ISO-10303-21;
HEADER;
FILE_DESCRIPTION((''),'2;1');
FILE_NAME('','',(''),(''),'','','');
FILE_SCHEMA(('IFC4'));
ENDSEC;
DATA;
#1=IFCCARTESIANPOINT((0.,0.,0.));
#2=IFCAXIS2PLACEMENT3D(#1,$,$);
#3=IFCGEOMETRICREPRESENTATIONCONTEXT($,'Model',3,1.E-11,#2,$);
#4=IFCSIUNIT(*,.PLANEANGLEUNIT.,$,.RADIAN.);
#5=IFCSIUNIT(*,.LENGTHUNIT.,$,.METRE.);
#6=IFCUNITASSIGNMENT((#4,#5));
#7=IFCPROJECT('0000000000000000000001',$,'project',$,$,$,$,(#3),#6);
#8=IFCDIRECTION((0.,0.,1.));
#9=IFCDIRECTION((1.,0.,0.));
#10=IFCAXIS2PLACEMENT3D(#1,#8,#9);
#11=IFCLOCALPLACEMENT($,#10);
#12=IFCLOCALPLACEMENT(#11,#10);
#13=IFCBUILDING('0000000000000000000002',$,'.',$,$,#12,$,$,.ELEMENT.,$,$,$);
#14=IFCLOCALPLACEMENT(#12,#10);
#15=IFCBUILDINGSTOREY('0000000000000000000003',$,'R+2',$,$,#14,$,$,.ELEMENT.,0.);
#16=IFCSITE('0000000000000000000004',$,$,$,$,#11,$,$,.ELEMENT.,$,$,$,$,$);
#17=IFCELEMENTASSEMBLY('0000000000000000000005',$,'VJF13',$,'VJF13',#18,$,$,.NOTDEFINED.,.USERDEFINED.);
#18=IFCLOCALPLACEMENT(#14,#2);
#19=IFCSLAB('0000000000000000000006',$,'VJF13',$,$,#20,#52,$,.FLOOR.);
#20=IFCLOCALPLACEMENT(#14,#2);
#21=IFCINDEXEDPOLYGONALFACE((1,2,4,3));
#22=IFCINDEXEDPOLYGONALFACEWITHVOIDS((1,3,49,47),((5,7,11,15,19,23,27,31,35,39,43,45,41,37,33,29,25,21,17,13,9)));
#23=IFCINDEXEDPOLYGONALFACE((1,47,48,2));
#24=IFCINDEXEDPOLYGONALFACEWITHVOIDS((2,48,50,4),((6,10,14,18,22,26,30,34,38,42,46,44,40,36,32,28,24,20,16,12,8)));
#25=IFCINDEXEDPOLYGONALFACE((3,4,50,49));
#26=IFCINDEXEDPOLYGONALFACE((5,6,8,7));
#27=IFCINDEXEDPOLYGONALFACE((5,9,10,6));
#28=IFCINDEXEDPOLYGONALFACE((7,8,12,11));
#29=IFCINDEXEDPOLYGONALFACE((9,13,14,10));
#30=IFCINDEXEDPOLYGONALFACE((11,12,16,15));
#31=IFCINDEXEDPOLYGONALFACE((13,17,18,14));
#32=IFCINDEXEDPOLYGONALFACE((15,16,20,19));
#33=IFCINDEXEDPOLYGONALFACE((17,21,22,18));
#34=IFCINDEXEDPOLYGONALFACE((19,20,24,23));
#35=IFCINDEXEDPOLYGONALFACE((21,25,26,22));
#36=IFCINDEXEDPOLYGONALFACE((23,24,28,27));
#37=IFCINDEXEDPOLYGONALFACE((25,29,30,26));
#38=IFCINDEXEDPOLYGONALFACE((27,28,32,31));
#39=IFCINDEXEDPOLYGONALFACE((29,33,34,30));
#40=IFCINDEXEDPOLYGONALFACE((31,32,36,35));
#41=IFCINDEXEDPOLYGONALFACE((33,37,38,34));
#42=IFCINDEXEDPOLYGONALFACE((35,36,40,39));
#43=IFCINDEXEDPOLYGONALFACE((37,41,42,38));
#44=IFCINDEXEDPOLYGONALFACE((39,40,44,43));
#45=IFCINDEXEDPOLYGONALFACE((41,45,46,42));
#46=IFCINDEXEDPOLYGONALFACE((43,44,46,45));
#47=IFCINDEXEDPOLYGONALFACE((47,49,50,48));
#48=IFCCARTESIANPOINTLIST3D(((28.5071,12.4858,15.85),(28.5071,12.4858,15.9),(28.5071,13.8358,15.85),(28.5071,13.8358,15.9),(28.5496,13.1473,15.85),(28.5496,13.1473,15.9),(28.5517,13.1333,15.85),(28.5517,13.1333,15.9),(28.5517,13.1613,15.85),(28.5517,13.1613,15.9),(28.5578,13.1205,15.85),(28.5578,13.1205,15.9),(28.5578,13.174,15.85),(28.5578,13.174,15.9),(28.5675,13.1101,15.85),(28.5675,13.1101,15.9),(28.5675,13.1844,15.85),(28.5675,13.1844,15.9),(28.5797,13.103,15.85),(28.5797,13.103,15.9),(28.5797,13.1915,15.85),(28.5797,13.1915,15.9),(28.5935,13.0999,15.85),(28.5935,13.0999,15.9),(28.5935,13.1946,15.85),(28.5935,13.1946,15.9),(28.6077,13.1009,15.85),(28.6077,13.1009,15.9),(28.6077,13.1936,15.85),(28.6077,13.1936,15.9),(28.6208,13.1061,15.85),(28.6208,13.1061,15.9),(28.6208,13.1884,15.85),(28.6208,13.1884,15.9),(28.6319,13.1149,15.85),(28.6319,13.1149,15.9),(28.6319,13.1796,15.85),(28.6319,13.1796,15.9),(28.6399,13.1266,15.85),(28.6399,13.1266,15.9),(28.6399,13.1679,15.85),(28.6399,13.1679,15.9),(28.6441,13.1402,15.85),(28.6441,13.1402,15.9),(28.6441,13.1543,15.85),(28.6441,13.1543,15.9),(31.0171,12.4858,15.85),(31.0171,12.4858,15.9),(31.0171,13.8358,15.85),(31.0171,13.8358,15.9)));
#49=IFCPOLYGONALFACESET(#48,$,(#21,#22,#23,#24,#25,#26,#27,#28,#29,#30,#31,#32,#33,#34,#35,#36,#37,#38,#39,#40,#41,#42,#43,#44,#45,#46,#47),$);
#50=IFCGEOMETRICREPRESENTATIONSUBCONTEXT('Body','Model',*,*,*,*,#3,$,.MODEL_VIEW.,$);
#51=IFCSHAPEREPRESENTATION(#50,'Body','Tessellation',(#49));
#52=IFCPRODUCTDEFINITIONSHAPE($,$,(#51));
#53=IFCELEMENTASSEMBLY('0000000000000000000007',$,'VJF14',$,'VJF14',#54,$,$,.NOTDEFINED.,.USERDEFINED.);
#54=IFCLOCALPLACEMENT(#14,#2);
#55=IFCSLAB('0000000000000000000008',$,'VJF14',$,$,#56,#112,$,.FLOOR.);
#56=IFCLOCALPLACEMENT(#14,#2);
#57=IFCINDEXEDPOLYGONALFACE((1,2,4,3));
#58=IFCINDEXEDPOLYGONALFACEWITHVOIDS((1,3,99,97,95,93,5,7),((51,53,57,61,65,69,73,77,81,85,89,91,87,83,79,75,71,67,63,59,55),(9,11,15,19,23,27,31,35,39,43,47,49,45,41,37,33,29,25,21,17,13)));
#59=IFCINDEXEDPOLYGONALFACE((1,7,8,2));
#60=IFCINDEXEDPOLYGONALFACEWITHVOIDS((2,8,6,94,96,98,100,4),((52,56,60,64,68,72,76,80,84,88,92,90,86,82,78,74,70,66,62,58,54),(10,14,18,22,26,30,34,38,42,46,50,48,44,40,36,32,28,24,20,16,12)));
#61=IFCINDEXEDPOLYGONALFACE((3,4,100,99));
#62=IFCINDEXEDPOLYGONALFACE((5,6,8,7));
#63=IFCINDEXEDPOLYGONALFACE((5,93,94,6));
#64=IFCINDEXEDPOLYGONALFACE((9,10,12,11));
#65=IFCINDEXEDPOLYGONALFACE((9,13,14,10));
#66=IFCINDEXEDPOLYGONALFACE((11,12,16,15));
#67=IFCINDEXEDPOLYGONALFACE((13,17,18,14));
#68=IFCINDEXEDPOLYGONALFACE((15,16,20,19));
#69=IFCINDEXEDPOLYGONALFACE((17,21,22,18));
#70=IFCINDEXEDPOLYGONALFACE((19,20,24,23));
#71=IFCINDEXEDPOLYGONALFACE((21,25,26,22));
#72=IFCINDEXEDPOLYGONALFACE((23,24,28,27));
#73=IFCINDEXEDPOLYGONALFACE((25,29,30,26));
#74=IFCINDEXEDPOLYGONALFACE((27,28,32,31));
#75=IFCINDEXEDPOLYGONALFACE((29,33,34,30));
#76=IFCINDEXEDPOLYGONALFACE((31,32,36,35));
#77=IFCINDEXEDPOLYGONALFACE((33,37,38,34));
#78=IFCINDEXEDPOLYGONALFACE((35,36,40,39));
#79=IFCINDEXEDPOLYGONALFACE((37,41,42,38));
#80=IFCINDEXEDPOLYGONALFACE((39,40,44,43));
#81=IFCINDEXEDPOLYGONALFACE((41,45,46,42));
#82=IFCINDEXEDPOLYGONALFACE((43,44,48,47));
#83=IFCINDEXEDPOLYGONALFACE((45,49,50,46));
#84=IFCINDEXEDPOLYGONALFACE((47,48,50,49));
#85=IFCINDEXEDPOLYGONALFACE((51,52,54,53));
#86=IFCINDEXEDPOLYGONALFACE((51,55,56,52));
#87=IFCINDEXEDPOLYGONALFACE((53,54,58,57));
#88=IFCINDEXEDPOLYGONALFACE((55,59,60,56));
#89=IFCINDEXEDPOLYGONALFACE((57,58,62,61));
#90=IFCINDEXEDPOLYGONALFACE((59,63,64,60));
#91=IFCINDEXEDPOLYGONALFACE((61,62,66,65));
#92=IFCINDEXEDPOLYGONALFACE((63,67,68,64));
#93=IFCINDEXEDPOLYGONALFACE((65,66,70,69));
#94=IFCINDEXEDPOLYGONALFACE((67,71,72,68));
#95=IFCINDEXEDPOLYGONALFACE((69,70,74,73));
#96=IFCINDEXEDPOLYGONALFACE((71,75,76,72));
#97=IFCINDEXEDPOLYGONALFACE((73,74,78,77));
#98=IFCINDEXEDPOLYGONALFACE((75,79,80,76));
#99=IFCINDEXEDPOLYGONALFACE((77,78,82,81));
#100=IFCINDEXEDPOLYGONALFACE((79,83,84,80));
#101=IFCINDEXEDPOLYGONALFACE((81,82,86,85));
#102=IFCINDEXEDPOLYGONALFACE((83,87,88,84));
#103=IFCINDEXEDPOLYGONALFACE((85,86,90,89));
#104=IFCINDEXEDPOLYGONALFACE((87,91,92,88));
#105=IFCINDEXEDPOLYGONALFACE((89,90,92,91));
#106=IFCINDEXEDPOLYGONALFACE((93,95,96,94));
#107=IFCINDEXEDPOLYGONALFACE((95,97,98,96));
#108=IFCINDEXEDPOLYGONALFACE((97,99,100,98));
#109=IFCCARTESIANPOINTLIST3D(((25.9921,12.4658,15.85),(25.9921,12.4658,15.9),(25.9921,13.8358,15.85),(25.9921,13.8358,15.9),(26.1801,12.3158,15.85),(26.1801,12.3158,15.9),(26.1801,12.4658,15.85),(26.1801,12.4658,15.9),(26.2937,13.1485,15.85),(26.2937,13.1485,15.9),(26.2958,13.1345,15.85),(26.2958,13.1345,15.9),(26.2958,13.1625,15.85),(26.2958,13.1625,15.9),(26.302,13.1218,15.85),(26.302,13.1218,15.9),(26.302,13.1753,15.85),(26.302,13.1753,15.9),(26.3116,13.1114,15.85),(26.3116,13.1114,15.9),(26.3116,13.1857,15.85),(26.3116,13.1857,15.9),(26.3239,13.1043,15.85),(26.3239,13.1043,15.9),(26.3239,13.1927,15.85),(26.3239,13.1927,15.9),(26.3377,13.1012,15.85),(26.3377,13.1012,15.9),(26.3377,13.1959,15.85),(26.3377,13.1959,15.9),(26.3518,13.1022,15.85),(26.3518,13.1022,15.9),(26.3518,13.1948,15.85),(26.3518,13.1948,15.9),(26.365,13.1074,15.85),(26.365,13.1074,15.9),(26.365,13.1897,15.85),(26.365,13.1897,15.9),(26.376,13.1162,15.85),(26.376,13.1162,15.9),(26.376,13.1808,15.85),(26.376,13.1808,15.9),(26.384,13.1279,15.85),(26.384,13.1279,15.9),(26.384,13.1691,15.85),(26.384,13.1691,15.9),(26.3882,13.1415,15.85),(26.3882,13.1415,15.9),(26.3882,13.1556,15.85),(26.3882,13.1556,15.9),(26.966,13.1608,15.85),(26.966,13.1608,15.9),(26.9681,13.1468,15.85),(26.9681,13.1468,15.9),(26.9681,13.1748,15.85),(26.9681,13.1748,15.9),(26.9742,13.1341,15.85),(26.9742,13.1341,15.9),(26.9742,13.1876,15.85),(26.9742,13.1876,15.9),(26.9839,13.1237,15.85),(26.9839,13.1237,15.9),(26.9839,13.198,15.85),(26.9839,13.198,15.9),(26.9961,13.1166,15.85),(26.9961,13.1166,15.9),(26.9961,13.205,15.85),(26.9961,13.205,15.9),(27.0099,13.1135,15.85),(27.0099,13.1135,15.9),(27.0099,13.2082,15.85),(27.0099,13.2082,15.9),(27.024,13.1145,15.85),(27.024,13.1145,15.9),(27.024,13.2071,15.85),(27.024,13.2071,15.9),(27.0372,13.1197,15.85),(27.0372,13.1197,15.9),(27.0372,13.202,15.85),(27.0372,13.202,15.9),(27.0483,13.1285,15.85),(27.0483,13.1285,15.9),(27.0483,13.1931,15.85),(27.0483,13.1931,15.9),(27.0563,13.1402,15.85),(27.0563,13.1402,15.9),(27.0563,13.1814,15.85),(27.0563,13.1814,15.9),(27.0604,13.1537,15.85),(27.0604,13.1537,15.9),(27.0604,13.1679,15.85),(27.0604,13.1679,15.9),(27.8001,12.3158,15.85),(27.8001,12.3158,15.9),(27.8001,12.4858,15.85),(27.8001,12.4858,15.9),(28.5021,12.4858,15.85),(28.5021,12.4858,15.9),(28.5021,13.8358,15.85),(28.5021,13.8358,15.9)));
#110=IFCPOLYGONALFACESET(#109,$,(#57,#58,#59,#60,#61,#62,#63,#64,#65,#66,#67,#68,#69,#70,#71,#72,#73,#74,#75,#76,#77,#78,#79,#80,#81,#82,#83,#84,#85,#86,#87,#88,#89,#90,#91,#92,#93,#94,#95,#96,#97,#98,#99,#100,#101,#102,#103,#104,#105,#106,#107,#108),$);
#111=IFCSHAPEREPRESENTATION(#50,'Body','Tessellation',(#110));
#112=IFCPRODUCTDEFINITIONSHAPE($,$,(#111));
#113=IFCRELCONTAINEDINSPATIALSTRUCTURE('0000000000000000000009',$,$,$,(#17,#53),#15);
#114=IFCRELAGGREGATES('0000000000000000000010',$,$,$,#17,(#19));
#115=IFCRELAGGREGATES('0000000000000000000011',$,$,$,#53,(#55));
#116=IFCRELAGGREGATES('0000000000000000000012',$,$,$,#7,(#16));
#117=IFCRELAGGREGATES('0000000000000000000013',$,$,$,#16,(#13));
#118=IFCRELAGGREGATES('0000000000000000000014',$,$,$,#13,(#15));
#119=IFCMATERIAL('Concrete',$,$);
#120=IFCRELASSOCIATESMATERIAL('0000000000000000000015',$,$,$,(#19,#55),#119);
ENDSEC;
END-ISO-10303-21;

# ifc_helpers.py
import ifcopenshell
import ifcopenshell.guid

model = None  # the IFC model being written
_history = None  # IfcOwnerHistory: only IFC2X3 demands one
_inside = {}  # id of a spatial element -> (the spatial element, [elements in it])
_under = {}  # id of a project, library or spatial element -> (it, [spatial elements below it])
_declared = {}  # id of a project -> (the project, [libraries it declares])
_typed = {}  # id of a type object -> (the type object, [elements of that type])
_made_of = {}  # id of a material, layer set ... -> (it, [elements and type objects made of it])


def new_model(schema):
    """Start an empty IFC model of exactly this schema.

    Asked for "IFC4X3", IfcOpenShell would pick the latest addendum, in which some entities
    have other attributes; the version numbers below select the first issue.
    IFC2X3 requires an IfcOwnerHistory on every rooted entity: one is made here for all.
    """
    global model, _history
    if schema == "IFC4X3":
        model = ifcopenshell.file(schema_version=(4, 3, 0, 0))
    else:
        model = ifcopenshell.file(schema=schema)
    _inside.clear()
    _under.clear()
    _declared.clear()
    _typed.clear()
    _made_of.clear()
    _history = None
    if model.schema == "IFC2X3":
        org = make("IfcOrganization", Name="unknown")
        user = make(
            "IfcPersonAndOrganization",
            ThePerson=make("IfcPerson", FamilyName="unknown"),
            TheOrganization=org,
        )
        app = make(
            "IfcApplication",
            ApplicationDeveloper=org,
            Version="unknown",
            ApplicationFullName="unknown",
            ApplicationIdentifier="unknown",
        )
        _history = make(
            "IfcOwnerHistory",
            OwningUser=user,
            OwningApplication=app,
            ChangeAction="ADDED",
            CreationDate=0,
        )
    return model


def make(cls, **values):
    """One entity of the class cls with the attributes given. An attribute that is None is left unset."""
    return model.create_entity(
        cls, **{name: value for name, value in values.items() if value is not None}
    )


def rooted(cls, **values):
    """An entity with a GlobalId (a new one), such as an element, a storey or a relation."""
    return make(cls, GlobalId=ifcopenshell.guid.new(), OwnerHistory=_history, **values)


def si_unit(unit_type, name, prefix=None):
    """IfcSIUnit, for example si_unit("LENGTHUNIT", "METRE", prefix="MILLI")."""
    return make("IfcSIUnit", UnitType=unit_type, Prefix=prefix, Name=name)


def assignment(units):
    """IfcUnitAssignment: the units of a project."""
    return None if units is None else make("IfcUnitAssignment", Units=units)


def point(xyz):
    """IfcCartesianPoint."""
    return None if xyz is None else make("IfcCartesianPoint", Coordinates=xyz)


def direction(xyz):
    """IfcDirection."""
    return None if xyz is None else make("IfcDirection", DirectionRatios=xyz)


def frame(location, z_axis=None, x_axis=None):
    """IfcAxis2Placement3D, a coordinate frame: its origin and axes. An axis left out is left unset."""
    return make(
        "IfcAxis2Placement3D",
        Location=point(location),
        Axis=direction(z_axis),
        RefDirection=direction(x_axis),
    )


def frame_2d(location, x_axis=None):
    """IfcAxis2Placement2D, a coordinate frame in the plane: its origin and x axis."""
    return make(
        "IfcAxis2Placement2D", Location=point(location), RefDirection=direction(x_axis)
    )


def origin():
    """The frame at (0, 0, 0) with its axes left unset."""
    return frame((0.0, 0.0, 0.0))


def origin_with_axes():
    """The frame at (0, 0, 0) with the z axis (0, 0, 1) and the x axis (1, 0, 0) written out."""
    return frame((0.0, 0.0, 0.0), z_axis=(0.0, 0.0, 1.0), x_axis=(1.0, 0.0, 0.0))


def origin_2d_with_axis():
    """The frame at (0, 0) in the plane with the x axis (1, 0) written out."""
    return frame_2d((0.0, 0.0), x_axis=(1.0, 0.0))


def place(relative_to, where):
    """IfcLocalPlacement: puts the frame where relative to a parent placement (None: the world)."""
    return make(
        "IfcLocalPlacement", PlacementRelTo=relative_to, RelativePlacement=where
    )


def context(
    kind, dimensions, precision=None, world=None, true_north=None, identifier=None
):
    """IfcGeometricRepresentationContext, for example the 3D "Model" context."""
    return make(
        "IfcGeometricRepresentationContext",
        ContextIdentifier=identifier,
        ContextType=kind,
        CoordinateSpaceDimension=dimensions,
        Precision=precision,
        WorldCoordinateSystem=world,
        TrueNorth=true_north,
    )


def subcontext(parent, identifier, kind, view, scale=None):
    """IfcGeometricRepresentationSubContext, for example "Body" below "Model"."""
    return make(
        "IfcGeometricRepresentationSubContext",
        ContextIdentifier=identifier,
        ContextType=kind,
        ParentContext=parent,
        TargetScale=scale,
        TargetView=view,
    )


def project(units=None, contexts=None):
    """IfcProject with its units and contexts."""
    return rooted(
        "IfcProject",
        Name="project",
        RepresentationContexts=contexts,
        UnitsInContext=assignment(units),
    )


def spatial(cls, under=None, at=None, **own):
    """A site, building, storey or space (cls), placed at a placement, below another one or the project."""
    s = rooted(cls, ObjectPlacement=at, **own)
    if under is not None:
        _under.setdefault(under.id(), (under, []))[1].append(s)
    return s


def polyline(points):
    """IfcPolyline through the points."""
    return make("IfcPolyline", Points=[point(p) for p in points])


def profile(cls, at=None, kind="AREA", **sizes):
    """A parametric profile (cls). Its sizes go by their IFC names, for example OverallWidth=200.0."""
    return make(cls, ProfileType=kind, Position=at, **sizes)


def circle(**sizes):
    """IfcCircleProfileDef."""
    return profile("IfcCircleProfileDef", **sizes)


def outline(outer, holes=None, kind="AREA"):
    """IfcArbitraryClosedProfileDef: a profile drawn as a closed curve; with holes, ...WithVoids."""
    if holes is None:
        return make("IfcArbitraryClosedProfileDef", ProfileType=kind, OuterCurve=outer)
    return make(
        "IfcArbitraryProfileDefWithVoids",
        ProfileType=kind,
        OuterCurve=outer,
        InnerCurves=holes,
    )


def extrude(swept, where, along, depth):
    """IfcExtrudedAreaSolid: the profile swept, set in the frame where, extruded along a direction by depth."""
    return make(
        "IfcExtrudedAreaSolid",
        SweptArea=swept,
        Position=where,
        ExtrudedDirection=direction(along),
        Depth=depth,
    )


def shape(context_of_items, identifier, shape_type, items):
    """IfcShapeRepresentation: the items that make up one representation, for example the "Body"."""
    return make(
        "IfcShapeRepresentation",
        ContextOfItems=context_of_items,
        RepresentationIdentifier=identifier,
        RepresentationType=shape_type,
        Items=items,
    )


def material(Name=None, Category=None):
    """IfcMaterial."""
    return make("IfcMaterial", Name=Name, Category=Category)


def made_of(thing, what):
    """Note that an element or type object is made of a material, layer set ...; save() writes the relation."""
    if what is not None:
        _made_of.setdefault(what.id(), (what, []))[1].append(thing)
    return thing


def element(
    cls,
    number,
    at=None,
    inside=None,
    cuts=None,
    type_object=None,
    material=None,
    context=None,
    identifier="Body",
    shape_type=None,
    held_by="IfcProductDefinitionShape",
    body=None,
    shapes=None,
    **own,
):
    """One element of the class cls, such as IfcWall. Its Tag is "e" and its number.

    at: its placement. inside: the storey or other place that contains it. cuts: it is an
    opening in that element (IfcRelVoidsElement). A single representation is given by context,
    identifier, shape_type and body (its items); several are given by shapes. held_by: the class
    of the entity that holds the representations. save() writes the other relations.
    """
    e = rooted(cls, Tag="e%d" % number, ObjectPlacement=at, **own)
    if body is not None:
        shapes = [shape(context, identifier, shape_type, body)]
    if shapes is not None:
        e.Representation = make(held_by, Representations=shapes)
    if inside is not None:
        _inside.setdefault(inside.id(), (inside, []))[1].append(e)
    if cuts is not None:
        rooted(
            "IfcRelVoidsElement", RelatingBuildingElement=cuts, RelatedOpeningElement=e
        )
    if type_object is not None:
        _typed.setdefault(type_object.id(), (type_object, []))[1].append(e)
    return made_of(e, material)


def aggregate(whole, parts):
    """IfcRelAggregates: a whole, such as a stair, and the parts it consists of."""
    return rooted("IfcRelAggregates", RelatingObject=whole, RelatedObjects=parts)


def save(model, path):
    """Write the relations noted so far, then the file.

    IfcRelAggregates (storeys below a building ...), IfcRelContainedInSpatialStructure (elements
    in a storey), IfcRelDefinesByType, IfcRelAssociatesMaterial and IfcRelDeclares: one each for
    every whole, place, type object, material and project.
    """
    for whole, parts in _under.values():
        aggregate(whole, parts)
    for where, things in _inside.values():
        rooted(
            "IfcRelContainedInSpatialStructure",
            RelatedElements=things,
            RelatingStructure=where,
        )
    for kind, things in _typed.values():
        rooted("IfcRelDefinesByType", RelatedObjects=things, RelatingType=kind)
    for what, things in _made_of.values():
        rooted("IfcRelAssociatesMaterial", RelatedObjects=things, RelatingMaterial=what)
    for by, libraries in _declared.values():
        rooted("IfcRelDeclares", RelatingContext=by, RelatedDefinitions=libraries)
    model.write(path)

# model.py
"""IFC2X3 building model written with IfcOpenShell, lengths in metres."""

from ifc_helpers import new_model, si_unit, frame, origin, origin_with_axes, origin_2d_with_axis, place, context, subcontext, project, spatial, polyline, circle, outline, extrude, material, element, aggregate, save


model = new_model("IFC2X3")

# Units and contexts
model_context = context("Model", 3, precision=1e-11, world=origin())
body_context = subcontext(model_context, "Body", "Model", "MODEL_VIEW")
ifc_project = project(units=[si_unit("PLANEANGLEUNIT", "RADIAN"), si_unit("LENGTHUNIT", "METRE")], contexts=[model_context])

# Site, building, storey
site_placement = place(None, origin_with_axes())
site = spatial("IfcSite", under=ifc_project, at=site_placement, CompositionType="ELEMENT")
building_placement = place(site_placement, origin_with_axes())
building = spatial("IfcBuilding", under=site, at=building_placement, Name=".", CompositionType="ELEMENT")
storey_placement = place(building_placement, origin_with_axes())
storey = spatial("IfcBuildingStorey", under=building, at=storey_placement, Name="R+2", CompositionType="ELEMENT", Elevation=0.0)

# Element assembly, slab, opening
assembly_1_placement = place(storey_placement, origin_with_axes())
assembly_1 = element("IfcElementAssembly", 1, at=assembly_1_placement, inside=storey, Name="VJF13", ObjectType="VJF13", AssemblyPlace="NOTDEFINED", PredefinedType="USERDEFINED")
ifc_material = material(Name="Concrete")
slab_1_placement = place(assembly_1_placement, frame((31.0171, 12.4858, 15.85), z_axis=(0.0, 0.0, 1.0), x_axis=(0.0, 1.0, 0.0)))
slab_1 = element("IfcSlab", 2, at=slab_1_placement, material=ifc_material, Name="VJF13", PredefinedType="FLOOR", context=body_context, shape_type="SweptSolid", body=[
    extrude(outline(polyline([(0.0, 0.0), (0.0, -1.35), (2.51, -1.35), (2.51, 0.0), (0.0, 0.0)])), frame((0.0, 0.0, 0.0), z_axis=(0.0, 0.0, 1.0), x_axis=(0.0, 1.0, 0.0)), (0.0, 0.0, 1.0), 0.05),
])
opening_1_placement = place(slab_1_placement, frame((0.6614, 2.42, 0.0), z_axis=(0.0, 0.0, 1.0), x_axis=(1.0, 0.0, 0.0)))
element("IfcOpeningElement", 3, at=opening_1_placement, cuts=slab_1, ObjectType="Opening", context=body_context, shape_type="SweptSolid", body=[
    extrude(circle(Radius=0.0475, at=origin_2d_with_axis()), frame((0.0, 0.0, 0.0), z_axis=(0.0, 0.0, 1.0), x_axis=(0.0, 1.0, 0.0)), (0.0, 0.0, 1.0), 0.05),
])

# Element assembly, slab, openings
assembly_2_placement = place(storey_placement, origin_with_axes())
assembly_2 = element("IfcElementAssembly", 4, at=assembly_2_placement, inside=storey, Name="VJF14", ObjectType="VJF14", AssemblyPlace="NOTDEFINED", PredefinedType="USERDEFINED")
slab_2_placement = place(assembly_2_placement, frame((28.5021, 12.3158, 15.85), z_axis=(0.0, 0.0, 1.0), x_axis=(0.0, 1.0, 0.0)))
slab_2 = element("IfcSlab", 5, at=slab_2_placement, material=ifc_material, Name="VJF14", PredefinedType="FLOOR", context=body_context, shape_type="SweptSolid", body=[
    extrude(outline(polyline([(0.0, -0.17), (0.0, -1.52), (2.51, -1.52), (2.51, -0.15), (2.322, -0.15), (2.322, 0.0), (0.702, 0.0), (0.702, -0.17), (0.0, -0.17)])), frame((0.0, 0.0, 0.0), z_axis=(0.0, 0.0, 1.0), x_axis=(0.0, 1.0, 0.0)), (0.0, 0.0, 1.0), 0.05),
])
opening_2_placement = place(slab_2_placement, frame((0.845, 1.4886, 0.0), z_axis=(0.0, 0.0, 1.0), x_axis=(1.0, 0.0, 0.0)))
element("IfcOpeningElement", 6, at=opening_2_placement, cuts=slab_2, ObjectType="Opening", context=body_context, shape_type="SweptSolid", body=[
    extrude(circle(Radius=0.0475, at=origin_2d_with_axis()), frame((0.0, 0.0, 0.0), z_axis=(0.0, 0.0, 1.0), x_axis=(0.0, 1.0, 0.0)), (0.0, 0.0, 1.0), 0.05),
])
opening_3_placement = place(slab_2_placement, frame((0.8327, 2.1609, 0.0), z_axis=(0.0, 0.0, 1.0), x_axis=(1.0, 0.0, 0.0)))
element("IfcOpeningElement", 7, at=opening_3_placement, cuts=slab_2, ObjectType="Opening", context=body_context, shape_type="SweptSolid", body=[
    extrude(circle(Radius=0.0475, at=origin_2d_with_axis()), frame((0.0, 0.0, 0.0), z_axis=(0.0, 0.0, 1.0), x_axis=(0.0, 1.0, 0.0)), (0.0, 0.0, 1.0), 0.05),
])

aggregate(assembly_1, [slab_1])
aggregate(assembly_2, [slab_2])

save(model, "model.ifc")
